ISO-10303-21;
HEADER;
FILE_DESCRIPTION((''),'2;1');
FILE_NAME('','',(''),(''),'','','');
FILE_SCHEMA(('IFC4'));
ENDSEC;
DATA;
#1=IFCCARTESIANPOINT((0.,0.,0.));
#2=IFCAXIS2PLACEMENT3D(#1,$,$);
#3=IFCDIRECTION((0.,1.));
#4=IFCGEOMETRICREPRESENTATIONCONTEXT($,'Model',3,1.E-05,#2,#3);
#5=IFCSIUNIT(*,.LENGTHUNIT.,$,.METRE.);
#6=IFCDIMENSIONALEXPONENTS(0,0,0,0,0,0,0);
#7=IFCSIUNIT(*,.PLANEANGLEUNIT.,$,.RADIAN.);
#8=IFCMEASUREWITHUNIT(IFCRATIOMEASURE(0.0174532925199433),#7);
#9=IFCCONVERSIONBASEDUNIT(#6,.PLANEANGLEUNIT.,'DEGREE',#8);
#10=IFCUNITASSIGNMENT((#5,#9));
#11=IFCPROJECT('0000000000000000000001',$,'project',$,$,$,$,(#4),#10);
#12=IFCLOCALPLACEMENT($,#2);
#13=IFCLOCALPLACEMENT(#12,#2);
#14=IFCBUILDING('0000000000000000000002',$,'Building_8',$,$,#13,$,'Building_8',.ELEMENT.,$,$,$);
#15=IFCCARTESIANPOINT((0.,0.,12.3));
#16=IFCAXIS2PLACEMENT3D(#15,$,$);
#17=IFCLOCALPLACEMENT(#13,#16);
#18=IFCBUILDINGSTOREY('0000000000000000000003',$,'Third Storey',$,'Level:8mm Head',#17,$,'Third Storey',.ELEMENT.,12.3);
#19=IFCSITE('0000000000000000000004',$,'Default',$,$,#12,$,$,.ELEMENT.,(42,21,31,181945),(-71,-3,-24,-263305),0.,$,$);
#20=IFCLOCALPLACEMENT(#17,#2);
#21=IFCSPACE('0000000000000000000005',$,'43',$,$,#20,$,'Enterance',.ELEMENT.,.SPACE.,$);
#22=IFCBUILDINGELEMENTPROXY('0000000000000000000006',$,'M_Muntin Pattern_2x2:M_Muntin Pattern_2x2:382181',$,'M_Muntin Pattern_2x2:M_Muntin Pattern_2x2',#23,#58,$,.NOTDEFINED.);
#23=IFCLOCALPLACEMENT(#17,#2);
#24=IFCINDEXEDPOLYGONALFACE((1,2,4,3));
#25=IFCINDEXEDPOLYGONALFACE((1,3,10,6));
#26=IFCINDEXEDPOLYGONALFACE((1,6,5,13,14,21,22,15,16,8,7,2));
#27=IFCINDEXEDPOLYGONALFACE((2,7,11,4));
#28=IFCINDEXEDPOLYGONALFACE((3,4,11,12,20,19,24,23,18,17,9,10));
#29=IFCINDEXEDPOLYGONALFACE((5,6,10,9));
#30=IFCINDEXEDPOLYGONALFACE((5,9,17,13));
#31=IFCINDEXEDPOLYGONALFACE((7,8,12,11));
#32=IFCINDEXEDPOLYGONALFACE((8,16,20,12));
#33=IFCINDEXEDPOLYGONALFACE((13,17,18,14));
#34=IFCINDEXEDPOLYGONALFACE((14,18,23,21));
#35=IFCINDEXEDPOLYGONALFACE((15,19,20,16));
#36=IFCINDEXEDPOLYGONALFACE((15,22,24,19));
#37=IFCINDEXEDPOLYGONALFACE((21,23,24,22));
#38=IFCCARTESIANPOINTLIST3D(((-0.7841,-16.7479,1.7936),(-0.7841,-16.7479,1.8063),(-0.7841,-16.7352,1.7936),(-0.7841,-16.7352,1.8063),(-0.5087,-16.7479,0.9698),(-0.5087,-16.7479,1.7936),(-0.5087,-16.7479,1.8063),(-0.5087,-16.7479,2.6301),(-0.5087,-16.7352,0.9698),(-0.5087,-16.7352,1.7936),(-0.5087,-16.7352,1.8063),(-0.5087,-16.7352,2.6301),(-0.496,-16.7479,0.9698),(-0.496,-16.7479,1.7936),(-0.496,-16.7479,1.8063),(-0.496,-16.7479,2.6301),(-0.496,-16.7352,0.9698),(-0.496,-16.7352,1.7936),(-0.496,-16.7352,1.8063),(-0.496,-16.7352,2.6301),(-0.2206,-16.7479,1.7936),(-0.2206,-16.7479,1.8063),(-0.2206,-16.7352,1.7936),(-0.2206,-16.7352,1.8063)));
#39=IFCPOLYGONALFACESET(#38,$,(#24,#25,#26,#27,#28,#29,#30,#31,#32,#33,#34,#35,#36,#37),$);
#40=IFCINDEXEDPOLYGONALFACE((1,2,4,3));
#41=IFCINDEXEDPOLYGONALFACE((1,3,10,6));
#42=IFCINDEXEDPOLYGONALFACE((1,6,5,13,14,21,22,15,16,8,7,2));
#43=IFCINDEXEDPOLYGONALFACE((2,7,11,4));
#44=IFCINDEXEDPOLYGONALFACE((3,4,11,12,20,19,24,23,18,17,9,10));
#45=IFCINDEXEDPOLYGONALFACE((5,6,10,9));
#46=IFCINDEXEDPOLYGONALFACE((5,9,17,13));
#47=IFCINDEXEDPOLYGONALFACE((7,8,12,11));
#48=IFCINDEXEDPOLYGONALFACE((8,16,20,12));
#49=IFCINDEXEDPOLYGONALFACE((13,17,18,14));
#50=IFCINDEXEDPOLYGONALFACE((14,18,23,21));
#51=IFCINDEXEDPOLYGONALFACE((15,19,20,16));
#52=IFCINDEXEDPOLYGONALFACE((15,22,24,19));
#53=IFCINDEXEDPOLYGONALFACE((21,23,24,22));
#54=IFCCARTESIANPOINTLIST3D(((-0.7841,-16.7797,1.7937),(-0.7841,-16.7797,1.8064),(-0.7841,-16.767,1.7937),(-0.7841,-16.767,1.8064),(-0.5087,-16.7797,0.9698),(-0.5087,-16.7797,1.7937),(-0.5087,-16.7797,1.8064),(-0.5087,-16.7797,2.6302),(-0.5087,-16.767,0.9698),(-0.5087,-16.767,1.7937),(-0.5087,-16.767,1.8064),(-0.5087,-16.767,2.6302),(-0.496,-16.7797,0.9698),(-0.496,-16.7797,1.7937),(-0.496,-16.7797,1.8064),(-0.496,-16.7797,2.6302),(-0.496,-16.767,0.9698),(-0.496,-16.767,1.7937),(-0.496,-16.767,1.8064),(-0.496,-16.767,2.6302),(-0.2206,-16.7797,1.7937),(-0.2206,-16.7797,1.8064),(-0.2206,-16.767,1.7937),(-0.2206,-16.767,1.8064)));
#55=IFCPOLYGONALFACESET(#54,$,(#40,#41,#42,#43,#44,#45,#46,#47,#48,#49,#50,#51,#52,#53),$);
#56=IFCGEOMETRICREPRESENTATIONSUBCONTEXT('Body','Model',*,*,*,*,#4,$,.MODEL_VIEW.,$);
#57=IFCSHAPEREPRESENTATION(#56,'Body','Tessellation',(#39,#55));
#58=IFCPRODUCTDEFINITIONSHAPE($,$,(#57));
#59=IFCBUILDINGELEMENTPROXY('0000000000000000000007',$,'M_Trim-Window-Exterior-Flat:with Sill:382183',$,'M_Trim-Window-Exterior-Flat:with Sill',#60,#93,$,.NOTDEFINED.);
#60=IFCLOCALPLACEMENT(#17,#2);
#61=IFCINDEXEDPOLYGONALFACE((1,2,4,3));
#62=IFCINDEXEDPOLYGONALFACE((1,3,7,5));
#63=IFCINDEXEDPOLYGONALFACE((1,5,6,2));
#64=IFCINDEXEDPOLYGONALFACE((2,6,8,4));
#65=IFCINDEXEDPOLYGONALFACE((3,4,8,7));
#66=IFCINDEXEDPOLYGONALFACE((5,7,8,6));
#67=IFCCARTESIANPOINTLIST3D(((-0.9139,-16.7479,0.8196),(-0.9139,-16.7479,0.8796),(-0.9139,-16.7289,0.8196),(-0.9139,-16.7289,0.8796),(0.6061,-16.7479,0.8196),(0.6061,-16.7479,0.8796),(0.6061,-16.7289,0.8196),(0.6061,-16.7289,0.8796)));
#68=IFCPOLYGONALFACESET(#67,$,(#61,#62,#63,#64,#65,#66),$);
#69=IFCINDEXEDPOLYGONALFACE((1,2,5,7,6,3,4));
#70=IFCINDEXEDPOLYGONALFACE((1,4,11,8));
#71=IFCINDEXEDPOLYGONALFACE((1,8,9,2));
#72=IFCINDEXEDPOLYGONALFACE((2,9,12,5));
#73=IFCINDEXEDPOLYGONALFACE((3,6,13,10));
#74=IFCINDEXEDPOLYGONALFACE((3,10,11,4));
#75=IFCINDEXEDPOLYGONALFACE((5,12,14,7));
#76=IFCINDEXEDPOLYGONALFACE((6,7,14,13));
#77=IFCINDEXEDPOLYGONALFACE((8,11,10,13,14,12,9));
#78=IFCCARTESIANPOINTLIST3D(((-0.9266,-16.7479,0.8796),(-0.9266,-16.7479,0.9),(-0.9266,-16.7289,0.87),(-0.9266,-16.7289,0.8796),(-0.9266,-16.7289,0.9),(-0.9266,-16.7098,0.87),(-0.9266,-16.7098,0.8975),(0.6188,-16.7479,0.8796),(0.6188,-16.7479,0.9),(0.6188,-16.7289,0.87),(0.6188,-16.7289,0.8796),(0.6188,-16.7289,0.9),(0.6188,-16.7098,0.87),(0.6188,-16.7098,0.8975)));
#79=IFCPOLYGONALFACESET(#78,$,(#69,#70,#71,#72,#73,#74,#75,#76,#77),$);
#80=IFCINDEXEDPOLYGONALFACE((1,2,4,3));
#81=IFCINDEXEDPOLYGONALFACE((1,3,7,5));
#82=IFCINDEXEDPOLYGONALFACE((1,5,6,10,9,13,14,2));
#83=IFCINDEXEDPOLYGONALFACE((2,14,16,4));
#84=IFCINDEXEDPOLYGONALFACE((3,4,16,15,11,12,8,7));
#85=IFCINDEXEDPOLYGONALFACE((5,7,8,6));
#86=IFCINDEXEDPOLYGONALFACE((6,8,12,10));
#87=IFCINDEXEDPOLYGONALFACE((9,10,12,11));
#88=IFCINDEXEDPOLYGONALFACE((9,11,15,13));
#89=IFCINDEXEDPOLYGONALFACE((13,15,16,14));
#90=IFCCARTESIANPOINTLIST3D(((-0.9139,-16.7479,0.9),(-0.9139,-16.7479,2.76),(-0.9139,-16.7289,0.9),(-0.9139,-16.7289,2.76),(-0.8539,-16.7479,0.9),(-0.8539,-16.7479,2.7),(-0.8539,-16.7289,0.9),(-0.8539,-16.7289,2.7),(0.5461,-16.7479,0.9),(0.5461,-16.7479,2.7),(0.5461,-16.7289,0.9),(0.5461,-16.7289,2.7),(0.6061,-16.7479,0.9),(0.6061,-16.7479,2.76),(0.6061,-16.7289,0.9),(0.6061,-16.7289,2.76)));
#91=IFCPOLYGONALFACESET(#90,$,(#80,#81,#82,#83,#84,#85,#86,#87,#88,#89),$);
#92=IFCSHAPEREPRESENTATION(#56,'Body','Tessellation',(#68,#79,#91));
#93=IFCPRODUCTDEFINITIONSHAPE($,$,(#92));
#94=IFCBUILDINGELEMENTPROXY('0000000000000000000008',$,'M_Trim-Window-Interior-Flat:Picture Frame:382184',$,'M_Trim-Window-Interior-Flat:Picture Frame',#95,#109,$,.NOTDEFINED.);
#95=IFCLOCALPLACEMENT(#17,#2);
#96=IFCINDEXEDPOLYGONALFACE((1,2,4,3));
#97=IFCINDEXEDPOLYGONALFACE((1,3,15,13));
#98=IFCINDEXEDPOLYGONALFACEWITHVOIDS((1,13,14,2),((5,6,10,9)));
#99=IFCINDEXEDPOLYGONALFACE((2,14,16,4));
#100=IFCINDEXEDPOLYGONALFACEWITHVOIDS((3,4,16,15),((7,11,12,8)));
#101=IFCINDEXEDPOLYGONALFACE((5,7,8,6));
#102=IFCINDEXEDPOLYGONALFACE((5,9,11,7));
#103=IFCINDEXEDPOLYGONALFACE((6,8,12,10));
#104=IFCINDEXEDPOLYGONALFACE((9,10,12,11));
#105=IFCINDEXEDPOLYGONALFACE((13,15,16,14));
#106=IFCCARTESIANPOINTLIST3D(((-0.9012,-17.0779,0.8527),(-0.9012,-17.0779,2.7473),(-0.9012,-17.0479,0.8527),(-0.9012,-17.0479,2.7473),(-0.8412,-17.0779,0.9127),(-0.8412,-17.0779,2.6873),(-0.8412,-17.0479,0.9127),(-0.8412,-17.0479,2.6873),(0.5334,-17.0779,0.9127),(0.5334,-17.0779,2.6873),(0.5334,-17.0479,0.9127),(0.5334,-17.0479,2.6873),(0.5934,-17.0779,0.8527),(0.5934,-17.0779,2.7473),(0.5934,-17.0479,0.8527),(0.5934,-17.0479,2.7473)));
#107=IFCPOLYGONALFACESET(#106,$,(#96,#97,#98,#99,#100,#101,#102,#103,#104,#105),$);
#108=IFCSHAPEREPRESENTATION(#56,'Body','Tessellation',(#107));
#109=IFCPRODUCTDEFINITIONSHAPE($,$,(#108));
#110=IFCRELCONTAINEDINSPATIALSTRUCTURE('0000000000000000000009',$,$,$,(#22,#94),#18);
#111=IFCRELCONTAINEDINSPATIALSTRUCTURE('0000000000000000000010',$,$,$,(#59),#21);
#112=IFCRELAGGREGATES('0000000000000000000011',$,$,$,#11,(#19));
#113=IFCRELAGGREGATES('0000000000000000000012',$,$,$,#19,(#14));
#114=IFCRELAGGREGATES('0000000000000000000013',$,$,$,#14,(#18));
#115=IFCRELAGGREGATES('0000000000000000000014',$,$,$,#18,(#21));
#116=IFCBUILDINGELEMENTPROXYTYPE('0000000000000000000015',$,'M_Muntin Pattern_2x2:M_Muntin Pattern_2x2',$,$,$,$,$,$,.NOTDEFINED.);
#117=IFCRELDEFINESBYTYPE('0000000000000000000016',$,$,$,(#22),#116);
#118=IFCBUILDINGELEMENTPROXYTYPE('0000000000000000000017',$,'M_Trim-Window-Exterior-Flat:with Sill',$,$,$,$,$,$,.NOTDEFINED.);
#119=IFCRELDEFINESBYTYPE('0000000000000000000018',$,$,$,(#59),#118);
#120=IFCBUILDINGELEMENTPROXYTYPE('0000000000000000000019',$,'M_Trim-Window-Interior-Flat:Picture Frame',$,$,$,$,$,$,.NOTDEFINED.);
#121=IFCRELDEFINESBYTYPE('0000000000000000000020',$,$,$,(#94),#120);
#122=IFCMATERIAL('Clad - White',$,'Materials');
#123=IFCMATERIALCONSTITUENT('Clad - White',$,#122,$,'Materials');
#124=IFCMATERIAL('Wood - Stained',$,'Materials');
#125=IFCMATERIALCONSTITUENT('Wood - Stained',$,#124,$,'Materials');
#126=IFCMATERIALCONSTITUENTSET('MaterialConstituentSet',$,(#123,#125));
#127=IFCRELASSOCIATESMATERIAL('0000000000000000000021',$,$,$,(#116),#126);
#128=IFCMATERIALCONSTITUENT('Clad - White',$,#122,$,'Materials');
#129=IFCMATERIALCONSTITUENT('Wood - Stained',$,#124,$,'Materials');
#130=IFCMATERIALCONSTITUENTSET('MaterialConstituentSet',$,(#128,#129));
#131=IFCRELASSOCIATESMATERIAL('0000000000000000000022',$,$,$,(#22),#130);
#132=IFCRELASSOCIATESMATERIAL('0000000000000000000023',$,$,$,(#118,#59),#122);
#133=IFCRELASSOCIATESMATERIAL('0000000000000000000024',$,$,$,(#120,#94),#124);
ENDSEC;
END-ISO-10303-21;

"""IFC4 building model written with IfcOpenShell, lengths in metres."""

from ifc_helpers import new_model, entity, si_unit, converted_unit, direction, frame, origin, place, context, subcontext, project, spatial, indexed_curve, outline, extrude, source, transform, mapped, material, constituent, constituent_set, type_object, type_shapes, element, save


model = new_model("IFC4")

# Units and contexts
model_context = context("Model", 3, precision=1e-05, world=origin(), true_north=direction((0.0, 1.0)))
body_context = subcontext(model_context, "Body", "Model", "MODEL_VIEW")
ifc_project = project(units=[si_unit("LENGTHUNIT", "METRE"), converted_unit("PLANEANGLEUNIT", "DEGREE", entity("IfcRatioMeasure", 0.0174532925199433), si_unit("PLANEANGLEUNIT", "RADIAN"), dimensions=[0, 0, 0, 0, 0, 0, 0])], contexts=[model_context])

# Site, building, storey
site_placement = place(None, origin())
site = spatial("IfcSite", under=ifc_project, at=site_placement, Name="Default", CompositionType="ELEMENT", RefLatitude=(42, 21, 31, 181945), RefLongitude=(-71, -3, -24, -263305), RefElevation=0.0)
building_placement = place(site_placement, origin())
building = spatial("IfcBuilding", under=site, at=building_placement, Name="Building_8", LongName="Building_8", CompositionType="ELEMENT")
storey_placement = place(building_placement, frame((0.0, 0.0, 12.3)))
storey = spatial("IfcBuildingStorey", under=building, at=storey_placement, Name="Third Storey", ObjectType="Level:8mm Head", LongName="Third Storey", CompositionType="ELEMENT", Elevation=12.3)

# Shared definitions
ifc_material_1 = material(Name="Clad - White", Category="Materials")
ifc_material_2 = material(Name="Wood - Stained", Category="Materials")

# Shared definitions
space_1_placement = place(storey_placement, origin())
space_1 = spatial("IfcSpace", under=storey, at=space_1_placement, Name="43", LongName="Enterance", CompositionType="ELEMENT", PredefinedType="SPACE")

# Building element proxies
ifc_constituent_1 = constituent(ifc_material_1, Name="Clad - White", Category="Materials")
ifc_constituent_2 = constituent(ifc_material_2, Name="Wood - Stained", Category="Materials")
ifc_constituent_set_1 = constituent_set(constituents=[ifc_constituent_1, ifc_constituent_2], Name="MaterialConstituentSet")
ifc_constituent_3 = constituent(ifc_material_1, Name="Clad - White", Category="Materials")
ifc_constituent_4 = constituent(ifc_material_2, Name="Wood - Stained", Category="Materials")
ifc_constituent_set_2 = constituent_set(constituents=[ifc_constituent_3, ifc_constituent_4], Name="MaterialConstituentSet")
building_element_proxy_type_1 = type_object("IfcBuildingElementProxyType", Name="M_Muntin Pattern_2x2:M_Muntin Pattern_2x2", PredefinedType="NOTDEFINED", material=ifc_constituent_set_2)
shared_shape_1 = source(origin(), body_context, "Body", "SweptSolid", [
    extrude(outline(indexed_curve([(0.0064, -0.0064), (0.8301, -0.0064), (0.8301, 0.0063), (0.0064, 0.0063), (0.0064, 0.2817), (-0.0063, 0.2817), (-0.0063, 0.0063), (-0.8302, 0.0063), (-0.8302, -0.0064), (-0.0063, -0.0064), (-0.0063, -0.2817), (0.0064, -0.2817), (0.0064, -0.0064)], self_intersect=False)), frame((0.0, 0.0095, 0.8301), z_axis=(0.0, 1.0, 0.0), x_axis=(0.0, 0.0, 1.0)), (0.0, 0.0, 1.0), 0.0127),
    extrude(outline(indexed_curve([(0.0064, -0.0064), (0.8302, -0.0064), (0.8302, 0.0063), (0.0064, 0.0063), (0.0064, 0.2817), (-0.0063, 0.2817), (-0.0063, 0.0063), (-0.8302, 0.0063), (-0.8302, -0.0064), (-0.0063, -0.0064), (-0.0063, -0.2817), (0.0064, -0.2817), (0.0064, -0.0064)], self_intersect=False)), frame((0.0, -0.0222, 0.8302), z_axis=(0.0, 1.0, 0.0), x_axis=(0.0, 0.0, 1.0)), (0.0, 0.0, 1.0), 0.0127),
])
type_shapes(building_element_proxy_type_1, [shared_shape_1])
proxy_1_placement = place(storey_placement, frame((-0.5023, -16.7575, 0.9698)))
element("IfcBuildingElementProxy", 1, at=proxy_1_placement, inside=storey, type_object=building_element_proxy_type_1, material=ifc_constituent_set_1, Name="M_Muntin Pattern_2x2:M_Muntin Pattern_2x2:382181", ObjectType="M_Muntin Pattern_2x2:M_Muntin Pattern_2x2", PredefinedType="NOTDEFINED", context=body_context, shape_type="MappedRepresentation", body=[
    mapped(shared_shape_1, transform((0.0, 0.0, 0.0), scale=1.0)),
])
building_element_proxy_type_2 = type_object("IfcBuildingElementProxyType", Name="M_Trim-Window-Exterior-Flat:with Sill", PredefinedType="NOTDEFINED", material=ifc_material_1)
shared_shape_2 = source(origin(), body_context, "Body", "SweptSolid", [
    extrude(outline(indexed_curve([(-0.76, -0.03), (0.76, -0.03), (0.76, 0.03), (-0.76, 0.03), (-0.76, -0.03)], self_intersect=False)), frame((0.0, -1.8504, 0.0), z_axis=(0.0, 0.0, 1.0), x_axis=(-1.0, 0.0, 0.0)), (0.0, 0.0, 1.0), 0.0191),
    extrude(outline(indexed_curve([(-0.019, -0.0152), (0.0, -0.0152), (0.0, -0.0057), (0.019, -0.0057), (0.019, 0.0148), (0.0, 0.0148), (-0.019, 0.0123), (-0.019, -0.0152)], self_intersect=False)), frame((-0.7727, -1.8148, 0.019), z_axis=(1.0, 0.0, 0.0), x_axis=(0.0, 0.0, -1.0)), (0.0, 0.0, 1.0), 1.5454),
    extrude(outline(indexed_curve([(-0.945, -0.76), (0.915, -0.76), (0.915, -0.7), (-0.885, -0.7), (-0.885, 0.7), (0.915, 0.7), (0.915, 0.76), (-0.945, 0.76), (-0.945, -0.76)], self_intersect=False)), frame((0.0, -0.885, 0.0), z_axis=(0.0, 0.0, 1.0), x_axis=(0.0, -1.0, 0.0)), (0.0, 0.0, 1.0), 0.0191),
])
type_shapes(building_element_proxy_type_2, [shared_shape_2])
proxy_2_placement = place(space_1_placement, frame((-0.1539, -16.7479, 2.7), z_axis=(0.0, 1.0, 0.0), x_axis=(-1.0, 0.0, 0.0)))
element("IfcBuildingElementProxy", 2, at=proxy_2_placement, inside=space_1, type_object=building_element_proxy_type_2, material=ifc_material_1, Name="M_Trim-Window-Exterior-Flat:with Sill:382183", ObjectType="M_Trim-Window-Exterior-Flat:with Sill", PredefinedType="NOTDEFINED", context=body_context, shape_type="MappedRepresentation", body=[
    mapped(shared_shape_2, transform((0.0, 0.0, 0.0), scale=1.0)),
])
building_element_proxy_type_3 = type_object("IfcBuildingElementProxyType", Name="M_Trim-Window-Interior-Flat:Picture Frame", PredefinedType="NOTDEFINED", material=ifc_material_2)
shared_shape_3 = source(origin(), body_context, "Body", "SweptSolid", [
    extrude(outline(indexed_curve([(-0.7473, -0.9473), (0.7473, -0.9473), (0.7473, 0.9473), (-0.7473, 0.9473), (-0.7473, -0.9473)], self_intersect=False), holes=[indexed_curve([(-0.6873, -0.8873), (-0.6873, 0.8873), (0.6873, 0.8873), (0.6873, -0.8873), (-0.6873, -0.8873)], self_intersect=False)]), frame((0.0, -0.9, 0.0), z_axis=(0.0, 0.0, 1.0), x_axis=(-1.0, 0.0, 0.0)), (0.0, 0.0, 1.0), 0.03),
])
type_shapes(building_element_proxy_type_3, [shared_shape_3])
proxy_3_placement = place(storey_placement, frame((-0.1539, -17.0479, 2.7), z_axis=(0.0, -1.0, 0.0), x_axis=(1.0, 0.0, 0.0)))
element("IfcBuildingElementProxy", 3, at=proxy_3_placement, inside=storey, type_object=building_element_proxy_type_3, material=ifc_material_2, Name="M_Trim-Window-Interior-Flat:Picture Frame:382184", ObjectType="M_Trim-Window-Interior-Flat:Picture Frame", PredefinedType="NOTDEFINED", context=body_context, shape_type="MappedRepresentation", body=[
    mapped(shared_shape_3, transform((0.0, 0.0, 0.0), scale=1.0)),
])

save(model, "model.ifc")
